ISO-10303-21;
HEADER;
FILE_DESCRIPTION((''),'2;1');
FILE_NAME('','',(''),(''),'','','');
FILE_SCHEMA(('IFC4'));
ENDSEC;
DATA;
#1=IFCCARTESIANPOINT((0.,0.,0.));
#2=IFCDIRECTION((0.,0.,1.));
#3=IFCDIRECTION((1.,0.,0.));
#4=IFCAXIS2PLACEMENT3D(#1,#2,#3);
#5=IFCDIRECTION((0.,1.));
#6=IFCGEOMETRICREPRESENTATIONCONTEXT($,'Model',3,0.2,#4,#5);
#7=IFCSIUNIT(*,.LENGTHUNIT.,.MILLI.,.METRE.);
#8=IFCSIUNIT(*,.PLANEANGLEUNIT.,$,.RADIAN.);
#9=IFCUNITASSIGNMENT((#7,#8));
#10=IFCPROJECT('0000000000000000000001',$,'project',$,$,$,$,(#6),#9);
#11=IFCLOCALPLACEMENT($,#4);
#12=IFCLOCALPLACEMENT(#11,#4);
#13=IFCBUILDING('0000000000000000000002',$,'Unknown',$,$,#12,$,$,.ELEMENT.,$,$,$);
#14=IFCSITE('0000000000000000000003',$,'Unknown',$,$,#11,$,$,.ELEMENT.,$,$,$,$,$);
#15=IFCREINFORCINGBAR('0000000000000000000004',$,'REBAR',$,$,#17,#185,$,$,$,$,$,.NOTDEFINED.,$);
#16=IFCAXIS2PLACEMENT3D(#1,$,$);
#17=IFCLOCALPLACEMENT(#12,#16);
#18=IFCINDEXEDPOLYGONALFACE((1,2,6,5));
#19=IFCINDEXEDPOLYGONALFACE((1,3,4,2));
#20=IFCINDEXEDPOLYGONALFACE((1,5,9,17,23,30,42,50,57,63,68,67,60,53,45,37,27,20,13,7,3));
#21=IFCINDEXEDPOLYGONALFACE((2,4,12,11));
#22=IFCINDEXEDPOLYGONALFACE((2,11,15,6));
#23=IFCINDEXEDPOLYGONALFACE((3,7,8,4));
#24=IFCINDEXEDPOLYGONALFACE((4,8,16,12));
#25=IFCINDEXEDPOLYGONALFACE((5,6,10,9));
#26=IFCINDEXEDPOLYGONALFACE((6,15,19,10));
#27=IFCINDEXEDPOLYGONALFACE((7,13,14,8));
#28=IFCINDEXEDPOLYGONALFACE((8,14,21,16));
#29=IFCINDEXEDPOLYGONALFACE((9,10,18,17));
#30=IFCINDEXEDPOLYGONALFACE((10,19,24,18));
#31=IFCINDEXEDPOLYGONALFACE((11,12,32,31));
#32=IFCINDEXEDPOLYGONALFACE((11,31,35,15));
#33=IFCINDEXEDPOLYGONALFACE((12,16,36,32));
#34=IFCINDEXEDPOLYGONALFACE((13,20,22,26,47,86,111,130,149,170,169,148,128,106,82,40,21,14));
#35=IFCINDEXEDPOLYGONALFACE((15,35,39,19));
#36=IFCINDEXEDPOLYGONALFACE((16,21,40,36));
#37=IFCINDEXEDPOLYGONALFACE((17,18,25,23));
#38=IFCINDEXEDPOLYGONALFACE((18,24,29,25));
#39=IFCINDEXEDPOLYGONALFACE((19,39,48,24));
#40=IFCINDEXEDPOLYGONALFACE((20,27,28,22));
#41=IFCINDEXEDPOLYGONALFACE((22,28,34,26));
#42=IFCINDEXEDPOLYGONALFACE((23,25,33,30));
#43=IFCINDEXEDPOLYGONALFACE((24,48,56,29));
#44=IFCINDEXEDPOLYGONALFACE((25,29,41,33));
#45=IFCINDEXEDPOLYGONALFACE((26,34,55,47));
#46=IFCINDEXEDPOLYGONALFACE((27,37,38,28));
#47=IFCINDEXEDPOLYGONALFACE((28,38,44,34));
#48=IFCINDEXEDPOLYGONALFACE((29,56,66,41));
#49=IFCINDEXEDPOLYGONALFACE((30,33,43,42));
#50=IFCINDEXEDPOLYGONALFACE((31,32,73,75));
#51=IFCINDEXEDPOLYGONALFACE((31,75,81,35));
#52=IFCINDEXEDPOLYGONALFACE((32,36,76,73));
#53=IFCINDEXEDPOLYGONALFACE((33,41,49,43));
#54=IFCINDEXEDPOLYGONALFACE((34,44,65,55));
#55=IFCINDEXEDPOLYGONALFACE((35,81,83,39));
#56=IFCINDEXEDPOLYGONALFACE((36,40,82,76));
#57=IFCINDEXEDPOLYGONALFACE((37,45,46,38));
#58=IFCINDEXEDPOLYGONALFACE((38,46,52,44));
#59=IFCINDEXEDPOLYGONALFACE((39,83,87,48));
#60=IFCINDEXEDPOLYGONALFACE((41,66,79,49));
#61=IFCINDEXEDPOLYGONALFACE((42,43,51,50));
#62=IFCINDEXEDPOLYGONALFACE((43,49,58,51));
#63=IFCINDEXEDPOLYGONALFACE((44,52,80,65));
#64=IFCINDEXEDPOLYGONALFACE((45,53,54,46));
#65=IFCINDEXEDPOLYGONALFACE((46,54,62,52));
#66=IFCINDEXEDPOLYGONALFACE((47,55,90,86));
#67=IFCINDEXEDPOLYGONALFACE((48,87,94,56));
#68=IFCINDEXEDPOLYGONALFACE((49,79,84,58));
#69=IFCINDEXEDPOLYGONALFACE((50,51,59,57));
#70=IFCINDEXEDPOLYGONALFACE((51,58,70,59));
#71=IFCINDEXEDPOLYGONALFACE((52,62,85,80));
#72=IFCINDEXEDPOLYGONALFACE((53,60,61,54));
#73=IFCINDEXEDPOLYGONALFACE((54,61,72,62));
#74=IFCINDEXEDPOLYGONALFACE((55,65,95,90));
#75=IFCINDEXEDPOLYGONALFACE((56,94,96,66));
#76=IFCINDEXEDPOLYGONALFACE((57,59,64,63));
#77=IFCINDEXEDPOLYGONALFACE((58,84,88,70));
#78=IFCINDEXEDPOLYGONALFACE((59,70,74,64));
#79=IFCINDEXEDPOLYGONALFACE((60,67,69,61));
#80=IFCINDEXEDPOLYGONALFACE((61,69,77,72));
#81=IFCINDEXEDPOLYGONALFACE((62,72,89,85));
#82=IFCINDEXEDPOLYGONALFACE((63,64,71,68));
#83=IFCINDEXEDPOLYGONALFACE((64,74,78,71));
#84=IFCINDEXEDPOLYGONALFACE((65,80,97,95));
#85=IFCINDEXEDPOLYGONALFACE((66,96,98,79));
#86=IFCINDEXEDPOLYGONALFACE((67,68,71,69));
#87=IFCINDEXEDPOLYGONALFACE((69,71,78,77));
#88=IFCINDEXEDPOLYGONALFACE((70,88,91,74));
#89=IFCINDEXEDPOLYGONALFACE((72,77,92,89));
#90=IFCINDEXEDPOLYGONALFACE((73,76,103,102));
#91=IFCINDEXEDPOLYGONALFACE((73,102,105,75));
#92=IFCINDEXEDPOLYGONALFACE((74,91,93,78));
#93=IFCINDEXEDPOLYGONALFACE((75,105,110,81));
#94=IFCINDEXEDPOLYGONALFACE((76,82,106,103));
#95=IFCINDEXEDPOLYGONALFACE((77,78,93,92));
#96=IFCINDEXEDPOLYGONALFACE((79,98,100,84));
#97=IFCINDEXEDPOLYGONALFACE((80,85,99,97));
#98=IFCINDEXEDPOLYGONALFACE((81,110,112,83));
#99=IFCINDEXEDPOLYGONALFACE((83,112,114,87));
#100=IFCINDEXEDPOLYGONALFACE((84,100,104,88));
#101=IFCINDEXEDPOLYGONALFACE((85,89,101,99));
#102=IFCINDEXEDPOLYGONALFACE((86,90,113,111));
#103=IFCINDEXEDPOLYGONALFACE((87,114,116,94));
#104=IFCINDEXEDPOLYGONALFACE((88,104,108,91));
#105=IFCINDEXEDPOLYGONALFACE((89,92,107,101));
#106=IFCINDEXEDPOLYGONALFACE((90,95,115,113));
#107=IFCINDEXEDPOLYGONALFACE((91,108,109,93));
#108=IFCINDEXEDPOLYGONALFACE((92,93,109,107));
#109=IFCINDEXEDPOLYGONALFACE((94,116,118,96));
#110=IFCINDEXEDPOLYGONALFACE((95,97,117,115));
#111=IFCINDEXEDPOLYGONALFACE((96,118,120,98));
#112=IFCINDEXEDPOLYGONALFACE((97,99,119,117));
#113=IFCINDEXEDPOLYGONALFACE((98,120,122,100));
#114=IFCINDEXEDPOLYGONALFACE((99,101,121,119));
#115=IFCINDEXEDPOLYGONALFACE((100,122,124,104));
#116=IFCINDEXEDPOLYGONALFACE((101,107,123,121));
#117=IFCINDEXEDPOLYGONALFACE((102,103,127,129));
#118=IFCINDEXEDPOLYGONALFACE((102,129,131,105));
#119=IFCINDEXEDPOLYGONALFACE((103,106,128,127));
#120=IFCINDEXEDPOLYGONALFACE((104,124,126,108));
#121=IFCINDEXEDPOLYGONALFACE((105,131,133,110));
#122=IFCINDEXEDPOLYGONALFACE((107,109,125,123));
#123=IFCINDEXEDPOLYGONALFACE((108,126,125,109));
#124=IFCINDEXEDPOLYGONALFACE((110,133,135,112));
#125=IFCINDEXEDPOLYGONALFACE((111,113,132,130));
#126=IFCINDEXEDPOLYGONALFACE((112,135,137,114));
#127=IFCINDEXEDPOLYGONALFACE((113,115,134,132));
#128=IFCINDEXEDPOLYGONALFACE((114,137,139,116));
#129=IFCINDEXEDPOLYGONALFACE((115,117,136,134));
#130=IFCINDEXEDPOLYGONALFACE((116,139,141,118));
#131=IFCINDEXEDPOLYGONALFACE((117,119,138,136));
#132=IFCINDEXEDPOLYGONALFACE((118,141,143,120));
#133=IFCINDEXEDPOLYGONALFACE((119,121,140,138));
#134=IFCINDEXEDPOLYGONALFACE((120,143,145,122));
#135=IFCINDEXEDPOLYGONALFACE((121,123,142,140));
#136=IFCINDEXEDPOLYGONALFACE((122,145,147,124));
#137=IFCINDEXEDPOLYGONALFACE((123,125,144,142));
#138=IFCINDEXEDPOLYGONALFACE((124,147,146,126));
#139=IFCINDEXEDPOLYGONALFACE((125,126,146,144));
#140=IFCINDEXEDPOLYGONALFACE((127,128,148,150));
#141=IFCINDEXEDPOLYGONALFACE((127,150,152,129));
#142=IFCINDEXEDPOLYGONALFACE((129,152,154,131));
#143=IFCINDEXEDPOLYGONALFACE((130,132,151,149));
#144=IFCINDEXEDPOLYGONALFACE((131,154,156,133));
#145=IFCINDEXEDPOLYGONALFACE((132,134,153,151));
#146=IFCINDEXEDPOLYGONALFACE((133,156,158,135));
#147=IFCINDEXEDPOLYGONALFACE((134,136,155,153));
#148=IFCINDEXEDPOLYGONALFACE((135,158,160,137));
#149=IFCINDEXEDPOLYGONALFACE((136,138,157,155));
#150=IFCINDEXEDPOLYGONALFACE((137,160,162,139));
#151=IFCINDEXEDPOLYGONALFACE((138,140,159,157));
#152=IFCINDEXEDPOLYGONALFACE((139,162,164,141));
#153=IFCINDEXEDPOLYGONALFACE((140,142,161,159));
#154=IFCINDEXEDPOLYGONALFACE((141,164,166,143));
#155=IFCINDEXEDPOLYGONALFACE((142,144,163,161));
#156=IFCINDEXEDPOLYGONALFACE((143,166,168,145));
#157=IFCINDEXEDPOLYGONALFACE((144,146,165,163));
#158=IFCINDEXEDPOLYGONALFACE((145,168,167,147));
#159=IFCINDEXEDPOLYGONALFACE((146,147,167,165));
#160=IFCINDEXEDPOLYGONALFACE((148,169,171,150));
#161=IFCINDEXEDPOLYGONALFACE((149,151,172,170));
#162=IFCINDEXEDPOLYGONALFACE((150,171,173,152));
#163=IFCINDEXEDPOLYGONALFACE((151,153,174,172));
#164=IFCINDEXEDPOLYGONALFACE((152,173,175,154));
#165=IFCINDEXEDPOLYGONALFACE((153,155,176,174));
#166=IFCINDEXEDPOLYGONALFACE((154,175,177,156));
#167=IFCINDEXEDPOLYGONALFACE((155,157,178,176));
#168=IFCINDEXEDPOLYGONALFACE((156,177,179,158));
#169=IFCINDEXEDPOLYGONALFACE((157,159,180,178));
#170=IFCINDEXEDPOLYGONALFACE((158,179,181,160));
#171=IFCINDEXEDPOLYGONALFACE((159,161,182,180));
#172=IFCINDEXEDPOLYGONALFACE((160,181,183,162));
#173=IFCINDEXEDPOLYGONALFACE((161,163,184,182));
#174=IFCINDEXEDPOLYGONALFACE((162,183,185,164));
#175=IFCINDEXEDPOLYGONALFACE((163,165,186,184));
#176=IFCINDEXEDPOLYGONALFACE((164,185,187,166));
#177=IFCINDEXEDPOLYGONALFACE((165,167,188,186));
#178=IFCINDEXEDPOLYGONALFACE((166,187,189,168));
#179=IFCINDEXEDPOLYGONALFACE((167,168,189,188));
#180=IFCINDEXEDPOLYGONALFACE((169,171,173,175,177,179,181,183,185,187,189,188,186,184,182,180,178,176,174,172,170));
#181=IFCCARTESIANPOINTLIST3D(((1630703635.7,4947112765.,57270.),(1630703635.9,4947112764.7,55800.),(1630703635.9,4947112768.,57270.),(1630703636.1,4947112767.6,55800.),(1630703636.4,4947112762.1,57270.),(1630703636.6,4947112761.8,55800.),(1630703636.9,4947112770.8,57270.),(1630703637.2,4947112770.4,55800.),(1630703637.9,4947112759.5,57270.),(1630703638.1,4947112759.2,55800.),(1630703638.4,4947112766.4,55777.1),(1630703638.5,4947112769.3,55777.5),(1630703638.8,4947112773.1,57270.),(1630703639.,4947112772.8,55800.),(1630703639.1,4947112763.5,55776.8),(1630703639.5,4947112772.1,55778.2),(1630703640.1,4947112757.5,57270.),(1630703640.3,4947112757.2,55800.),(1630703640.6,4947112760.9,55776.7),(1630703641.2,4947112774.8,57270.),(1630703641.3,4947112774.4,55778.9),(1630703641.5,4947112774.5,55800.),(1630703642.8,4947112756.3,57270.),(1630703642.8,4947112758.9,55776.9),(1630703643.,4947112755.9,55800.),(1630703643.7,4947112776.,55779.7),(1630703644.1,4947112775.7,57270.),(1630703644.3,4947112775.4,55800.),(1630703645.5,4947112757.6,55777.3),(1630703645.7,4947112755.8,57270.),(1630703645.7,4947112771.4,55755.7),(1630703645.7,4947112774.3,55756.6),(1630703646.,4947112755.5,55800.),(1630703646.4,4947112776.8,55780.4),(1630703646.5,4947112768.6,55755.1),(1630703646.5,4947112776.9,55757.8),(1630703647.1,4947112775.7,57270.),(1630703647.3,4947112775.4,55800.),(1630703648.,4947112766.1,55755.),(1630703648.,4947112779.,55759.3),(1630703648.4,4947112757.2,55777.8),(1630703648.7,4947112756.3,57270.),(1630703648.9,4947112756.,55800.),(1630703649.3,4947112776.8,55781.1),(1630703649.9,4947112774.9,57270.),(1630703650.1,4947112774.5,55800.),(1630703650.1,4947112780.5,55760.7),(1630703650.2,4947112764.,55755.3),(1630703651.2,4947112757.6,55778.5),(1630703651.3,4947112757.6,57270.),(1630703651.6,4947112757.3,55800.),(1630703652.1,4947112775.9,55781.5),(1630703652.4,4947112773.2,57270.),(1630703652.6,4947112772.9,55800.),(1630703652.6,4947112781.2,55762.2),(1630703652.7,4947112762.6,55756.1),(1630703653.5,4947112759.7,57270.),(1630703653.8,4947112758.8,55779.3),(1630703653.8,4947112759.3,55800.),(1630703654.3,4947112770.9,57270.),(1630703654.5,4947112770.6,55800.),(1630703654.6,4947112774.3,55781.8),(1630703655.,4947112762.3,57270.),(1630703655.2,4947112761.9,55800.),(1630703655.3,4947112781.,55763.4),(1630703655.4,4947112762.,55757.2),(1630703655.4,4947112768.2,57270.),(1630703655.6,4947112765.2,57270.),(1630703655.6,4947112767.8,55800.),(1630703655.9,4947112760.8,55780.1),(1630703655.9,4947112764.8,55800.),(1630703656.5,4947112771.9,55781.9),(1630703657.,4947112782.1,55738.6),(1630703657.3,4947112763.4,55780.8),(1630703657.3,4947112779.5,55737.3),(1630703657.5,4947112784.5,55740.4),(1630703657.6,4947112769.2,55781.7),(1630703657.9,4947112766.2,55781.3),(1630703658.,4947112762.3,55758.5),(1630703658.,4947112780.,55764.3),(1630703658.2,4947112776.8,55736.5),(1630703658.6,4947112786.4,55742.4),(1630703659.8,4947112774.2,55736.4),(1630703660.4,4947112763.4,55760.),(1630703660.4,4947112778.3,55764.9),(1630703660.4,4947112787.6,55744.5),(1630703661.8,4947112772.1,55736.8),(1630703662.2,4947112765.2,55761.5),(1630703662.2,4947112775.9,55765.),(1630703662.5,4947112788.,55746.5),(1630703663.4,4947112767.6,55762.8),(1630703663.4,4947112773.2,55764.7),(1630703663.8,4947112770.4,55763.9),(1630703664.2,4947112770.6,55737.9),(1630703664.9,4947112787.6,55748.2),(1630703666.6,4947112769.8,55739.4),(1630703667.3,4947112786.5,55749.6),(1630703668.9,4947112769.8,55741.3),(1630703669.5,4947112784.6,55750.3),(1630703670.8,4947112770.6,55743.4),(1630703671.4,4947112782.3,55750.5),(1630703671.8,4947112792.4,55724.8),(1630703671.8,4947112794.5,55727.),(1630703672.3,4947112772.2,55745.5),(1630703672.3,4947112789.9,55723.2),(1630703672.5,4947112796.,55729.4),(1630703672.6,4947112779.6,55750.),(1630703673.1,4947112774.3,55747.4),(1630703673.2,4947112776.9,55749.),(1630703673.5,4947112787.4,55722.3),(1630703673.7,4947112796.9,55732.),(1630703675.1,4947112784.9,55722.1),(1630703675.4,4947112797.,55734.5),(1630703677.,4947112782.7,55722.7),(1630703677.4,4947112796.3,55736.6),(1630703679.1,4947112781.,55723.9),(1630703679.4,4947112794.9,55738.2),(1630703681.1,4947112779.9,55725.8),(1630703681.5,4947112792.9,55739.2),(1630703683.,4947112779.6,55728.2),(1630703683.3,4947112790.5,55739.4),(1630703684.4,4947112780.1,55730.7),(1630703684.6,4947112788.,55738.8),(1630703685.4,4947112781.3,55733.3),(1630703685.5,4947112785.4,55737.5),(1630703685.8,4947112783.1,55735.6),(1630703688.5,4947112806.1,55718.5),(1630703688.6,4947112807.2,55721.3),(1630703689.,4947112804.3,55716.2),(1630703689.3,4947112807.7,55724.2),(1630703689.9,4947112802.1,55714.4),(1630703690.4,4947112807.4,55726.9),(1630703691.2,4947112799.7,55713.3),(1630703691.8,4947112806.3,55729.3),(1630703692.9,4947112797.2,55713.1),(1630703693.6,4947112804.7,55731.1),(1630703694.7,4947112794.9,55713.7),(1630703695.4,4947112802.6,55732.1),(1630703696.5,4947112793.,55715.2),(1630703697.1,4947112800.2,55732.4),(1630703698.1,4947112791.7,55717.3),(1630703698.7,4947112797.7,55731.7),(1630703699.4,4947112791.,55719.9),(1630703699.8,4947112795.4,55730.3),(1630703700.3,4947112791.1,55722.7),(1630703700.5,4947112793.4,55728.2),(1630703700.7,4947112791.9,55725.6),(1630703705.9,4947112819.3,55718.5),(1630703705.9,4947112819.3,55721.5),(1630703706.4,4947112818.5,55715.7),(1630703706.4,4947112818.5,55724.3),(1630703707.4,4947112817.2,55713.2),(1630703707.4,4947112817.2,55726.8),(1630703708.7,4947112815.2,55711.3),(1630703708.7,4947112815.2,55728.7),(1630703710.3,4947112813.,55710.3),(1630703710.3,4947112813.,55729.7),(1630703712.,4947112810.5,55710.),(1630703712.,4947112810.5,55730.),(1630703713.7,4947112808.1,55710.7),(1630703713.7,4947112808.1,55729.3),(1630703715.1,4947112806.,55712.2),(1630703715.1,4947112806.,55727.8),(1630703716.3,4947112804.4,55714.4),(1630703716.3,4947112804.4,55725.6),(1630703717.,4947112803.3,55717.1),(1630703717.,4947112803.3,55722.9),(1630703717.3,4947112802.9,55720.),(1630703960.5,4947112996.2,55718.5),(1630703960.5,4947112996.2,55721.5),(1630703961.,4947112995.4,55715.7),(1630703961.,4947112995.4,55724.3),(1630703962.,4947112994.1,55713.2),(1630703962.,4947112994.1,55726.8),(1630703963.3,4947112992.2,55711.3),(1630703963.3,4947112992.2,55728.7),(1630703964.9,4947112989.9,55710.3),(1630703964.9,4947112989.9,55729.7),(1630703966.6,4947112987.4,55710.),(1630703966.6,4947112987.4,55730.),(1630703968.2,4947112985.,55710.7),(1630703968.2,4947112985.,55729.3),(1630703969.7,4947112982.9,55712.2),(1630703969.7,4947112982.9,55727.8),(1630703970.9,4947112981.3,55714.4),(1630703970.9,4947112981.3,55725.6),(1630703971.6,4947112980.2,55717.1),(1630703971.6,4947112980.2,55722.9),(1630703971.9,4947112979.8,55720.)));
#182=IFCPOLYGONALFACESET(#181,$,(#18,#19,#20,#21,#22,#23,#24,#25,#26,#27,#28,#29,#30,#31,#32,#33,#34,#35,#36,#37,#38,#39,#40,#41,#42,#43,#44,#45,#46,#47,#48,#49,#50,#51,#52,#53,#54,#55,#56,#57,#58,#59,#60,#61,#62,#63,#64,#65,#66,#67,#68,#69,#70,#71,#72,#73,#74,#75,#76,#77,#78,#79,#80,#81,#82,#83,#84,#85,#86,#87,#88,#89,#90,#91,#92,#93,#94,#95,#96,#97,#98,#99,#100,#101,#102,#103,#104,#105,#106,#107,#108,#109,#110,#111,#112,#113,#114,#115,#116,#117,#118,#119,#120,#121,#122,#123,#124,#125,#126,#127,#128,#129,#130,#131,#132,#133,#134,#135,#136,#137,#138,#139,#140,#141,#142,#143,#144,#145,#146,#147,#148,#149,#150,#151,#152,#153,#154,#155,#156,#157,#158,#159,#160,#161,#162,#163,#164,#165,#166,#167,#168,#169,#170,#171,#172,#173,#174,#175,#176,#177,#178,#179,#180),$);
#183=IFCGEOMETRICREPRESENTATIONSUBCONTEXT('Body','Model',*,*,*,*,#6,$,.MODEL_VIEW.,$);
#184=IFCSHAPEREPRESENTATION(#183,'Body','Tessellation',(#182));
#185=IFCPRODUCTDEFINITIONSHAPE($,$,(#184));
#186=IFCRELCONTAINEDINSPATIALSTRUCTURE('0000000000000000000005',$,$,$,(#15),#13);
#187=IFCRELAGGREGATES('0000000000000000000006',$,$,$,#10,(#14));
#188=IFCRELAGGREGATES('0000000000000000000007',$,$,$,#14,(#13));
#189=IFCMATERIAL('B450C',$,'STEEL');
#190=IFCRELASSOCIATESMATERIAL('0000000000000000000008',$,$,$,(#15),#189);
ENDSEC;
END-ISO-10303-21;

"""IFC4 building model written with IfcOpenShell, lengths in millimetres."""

from ifc_helpers import new_model, entity, si_unit, direction, frame, origin_with_axes, place, context, subcontext, project, spatial, material, element, save


model = new_model("IFC4")

# Units and contexts
model_context = context("Model", 3, precision=0.2, world=origin_with_axes(), true_north=direction((0.0, 1.0)))
body_context = subcontext(model_context, "Body", "Model", "MODEL_VIEW")
ifc_project = project(units=[si_unit("LENGTHUNIT", "METRE", prefix="MILLI"), si_unit("PLANEANGLEUNIT", "RADIAN")], contexts=[model_context])

# Site, building
site_placement = place(None, origin_with_axes())
site = spatial("IfcSite", under=ifc_project, at=site_placement, Name="Unknown", CompositionType="ELEMENT")
building_placement = place(site_placement, origin_with_axes())
building = spatial("IfcBuilding", under=site, at=building_placement, Name="Unknown", CompositionType="ELEMENT")

# Reinforcing bar
ifc_material = material(Name="B450C", Category="STEEL")
reinforcing_bar_1_placement = place(building_placement, frame((1630703576.3, 4947112778.0, 55670.0), z_axis=(0.570957, -0.82098, 0.0), x_axis=(0.0, 0.0, 1.0)))
element("IfcReinforcingBar", 1, at=reinforcing_bar_1_placement, inside=building, material=ifc_material, Name="REBAR", PredefinedType="NOTDEFINED", context=body_context, shape_type="AdvancedSweptSolid", body=[
    entity("IfcSweptDiskSolid", entity("IfcIndexedPolyCurve", entity("IfcCartesianPointList3D", [[50.0, -440.0, 50.1], [50.0, -130.0, 50.0], [73.4, -73.4, 50.0], [130.0, -50.0, 50.0], [1600.0, -50.0, 49.6]]), [entity("IfcLineIndex", [1, 2]), entity("IfcArcIndex", [2, 3, 4]), entity("IfcLineIndex", [4, 5])]), 10.0),
])

save(model, "model.ifc")
